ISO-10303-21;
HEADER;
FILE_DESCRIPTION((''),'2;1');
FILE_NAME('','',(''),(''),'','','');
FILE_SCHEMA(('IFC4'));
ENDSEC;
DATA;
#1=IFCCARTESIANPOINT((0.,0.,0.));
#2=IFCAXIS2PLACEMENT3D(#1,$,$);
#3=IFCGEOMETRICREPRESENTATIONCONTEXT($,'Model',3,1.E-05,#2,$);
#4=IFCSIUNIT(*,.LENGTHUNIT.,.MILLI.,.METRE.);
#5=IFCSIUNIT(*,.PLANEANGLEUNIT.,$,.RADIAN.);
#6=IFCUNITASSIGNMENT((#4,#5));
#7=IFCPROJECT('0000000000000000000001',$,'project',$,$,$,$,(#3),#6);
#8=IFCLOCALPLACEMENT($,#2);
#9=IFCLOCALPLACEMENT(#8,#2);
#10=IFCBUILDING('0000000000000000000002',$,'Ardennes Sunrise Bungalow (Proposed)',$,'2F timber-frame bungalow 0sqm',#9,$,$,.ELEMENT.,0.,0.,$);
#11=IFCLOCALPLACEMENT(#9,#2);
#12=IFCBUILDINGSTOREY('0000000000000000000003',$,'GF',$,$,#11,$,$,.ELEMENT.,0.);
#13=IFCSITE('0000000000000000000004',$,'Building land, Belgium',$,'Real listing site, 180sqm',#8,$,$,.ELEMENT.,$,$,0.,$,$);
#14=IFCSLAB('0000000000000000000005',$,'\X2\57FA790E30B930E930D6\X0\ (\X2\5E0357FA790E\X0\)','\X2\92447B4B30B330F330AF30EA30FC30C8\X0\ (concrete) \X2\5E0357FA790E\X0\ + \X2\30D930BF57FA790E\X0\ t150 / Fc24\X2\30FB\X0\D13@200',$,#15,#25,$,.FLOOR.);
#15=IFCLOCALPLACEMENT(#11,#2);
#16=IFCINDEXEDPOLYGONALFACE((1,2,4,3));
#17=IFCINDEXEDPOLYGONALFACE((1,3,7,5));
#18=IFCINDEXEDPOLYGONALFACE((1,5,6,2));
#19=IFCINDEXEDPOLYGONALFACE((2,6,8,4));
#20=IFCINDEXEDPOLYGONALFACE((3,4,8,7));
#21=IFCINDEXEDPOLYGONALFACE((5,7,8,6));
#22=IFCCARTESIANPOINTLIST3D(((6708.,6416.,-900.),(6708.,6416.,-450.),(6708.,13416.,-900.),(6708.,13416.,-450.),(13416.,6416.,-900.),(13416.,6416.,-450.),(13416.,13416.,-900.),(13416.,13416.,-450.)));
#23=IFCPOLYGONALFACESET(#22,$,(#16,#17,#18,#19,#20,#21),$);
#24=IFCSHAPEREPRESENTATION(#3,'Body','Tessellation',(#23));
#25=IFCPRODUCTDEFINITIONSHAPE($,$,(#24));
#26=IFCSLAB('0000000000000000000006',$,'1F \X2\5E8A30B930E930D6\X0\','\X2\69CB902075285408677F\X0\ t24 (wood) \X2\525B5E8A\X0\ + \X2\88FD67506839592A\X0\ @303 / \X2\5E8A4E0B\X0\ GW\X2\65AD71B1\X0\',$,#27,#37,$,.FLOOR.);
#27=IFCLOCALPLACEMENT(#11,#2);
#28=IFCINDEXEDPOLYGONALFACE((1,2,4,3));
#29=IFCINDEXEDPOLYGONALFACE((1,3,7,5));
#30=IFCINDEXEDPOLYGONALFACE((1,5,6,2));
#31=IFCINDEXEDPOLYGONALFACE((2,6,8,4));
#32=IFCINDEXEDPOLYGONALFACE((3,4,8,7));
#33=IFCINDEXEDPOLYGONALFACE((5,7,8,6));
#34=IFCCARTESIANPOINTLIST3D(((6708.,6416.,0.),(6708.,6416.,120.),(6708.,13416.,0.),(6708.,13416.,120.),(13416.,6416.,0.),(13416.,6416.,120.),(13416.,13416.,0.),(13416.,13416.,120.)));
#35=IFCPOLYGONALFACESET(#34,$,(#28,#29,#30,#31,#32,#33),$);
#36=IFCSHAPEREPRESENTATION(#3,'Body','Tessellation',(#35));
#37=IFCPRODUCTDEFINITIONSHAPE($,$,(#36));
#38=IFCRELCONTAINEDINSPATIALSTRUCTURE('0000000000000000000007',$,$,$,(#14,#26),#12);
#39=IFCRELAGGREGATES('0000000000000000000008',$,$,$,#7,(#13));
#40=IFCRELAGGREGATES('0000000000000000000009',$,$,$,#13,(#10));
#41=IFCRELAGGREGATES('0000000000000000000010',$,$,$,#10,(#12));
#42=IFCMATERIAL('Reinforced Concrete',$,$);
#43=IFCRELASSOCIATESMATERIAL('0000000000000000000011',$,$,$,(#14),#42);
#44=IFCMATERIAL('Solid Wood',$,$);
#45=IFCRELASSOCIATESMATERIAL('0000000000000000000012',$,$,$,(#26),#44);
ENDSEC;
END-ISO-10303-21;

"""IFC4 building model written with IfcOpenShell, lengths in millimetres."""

from ifc_helpers import new_model, si_unit, frame, frame_2d, origin, place, context, project, spatial, rectangle, extrude, material, element, save


model = new_model("IFC4")

# Units and contexts
model_context = context("Model", 3, precision=1e-05, world=origin())
ifc_project = project(units=[si_unit("LENGTHUNIT", "METRE", prefix="MILLI"), si_unit("PLANEANGLEUNIT", "RADIAN")], contexts=[model_context])

# Site, building, storey
site_placement = place(None, origin())
site = spatial("IfcSite", under=ifc_project, at=site_placement, Name="Building land, Belgium", ObjectType="Real listing site, 180sqm", CompositionType="ELEMENT", RefElevation=0.0)
building_placement = place(site_placement, origin())
building = spatial("IfcBuilding", under=site, at=building_placement, Name="Ardennes Sunrise Bungalow (Proposed)", ObjectType="2F timber-frame bungalow 0sqm", CompositionType="ELEMENT", ElevationOfRefHeight=0.0, ElevationOfTerrain=0.0)
storey_placement = place(building_placement, origin())
storey = spatial("IfcBuildingStorey", under=building, at=storey_placement, Name="GF", CompositionType="ELEMENT", Elevation=0.0)

# Slabs
ifc_material_1 = material(Name="Reinforced Concrete")
slab_1_placement = place(storey_placement, frame((3354.0, 3208.0, -450.0)))
element("IfcSlab", 1, at=slab_1_placement, inside=storey, material=ifc_material_1, Name="基礎スラブ (布基礎)", Description="鉄筋コンクリート (concrete) 布基礎 + ベタ基礎 t150 / Fc24・D13@200", PredefinedType="FLOOR", context=model_context, shape_type="SweptSolid", body=[
    extrude(rectangle(XDim=6708.0, YDim=7000.0, at=frame_2d((3354.0, 3500.0))), frame((3354.0, 3208.0, -450.0)), (0.0, 0.0, 1.0), 450.0),
])
ifc_material_2 = material(Name="Solid Wood")
slab_2_placement = place(storey_placement, frame((3354.0, 3208.0, 0.0)))
element("IfcSlab", 2, at=slab_2_placement, inside=storey, material=ifc_material_2, Name="1F 床スラブ", Description="構造用合板 t24 (wood) 剛床 + 製材根太 @303 / 床下 GW断熱", PredefinedType="FLOOR", context=model_context, shape_type="SweptSolid", body=[
    extrude(rectangle(XDim=6708.0, YDim=7000.0, at=frame_2d((3354.0, 3500.0))), frame((3354.0, 3208.0, 0.0)), (0.0, 0.0, 1.0), 120.0),
])

save(model, "model.ifc")
